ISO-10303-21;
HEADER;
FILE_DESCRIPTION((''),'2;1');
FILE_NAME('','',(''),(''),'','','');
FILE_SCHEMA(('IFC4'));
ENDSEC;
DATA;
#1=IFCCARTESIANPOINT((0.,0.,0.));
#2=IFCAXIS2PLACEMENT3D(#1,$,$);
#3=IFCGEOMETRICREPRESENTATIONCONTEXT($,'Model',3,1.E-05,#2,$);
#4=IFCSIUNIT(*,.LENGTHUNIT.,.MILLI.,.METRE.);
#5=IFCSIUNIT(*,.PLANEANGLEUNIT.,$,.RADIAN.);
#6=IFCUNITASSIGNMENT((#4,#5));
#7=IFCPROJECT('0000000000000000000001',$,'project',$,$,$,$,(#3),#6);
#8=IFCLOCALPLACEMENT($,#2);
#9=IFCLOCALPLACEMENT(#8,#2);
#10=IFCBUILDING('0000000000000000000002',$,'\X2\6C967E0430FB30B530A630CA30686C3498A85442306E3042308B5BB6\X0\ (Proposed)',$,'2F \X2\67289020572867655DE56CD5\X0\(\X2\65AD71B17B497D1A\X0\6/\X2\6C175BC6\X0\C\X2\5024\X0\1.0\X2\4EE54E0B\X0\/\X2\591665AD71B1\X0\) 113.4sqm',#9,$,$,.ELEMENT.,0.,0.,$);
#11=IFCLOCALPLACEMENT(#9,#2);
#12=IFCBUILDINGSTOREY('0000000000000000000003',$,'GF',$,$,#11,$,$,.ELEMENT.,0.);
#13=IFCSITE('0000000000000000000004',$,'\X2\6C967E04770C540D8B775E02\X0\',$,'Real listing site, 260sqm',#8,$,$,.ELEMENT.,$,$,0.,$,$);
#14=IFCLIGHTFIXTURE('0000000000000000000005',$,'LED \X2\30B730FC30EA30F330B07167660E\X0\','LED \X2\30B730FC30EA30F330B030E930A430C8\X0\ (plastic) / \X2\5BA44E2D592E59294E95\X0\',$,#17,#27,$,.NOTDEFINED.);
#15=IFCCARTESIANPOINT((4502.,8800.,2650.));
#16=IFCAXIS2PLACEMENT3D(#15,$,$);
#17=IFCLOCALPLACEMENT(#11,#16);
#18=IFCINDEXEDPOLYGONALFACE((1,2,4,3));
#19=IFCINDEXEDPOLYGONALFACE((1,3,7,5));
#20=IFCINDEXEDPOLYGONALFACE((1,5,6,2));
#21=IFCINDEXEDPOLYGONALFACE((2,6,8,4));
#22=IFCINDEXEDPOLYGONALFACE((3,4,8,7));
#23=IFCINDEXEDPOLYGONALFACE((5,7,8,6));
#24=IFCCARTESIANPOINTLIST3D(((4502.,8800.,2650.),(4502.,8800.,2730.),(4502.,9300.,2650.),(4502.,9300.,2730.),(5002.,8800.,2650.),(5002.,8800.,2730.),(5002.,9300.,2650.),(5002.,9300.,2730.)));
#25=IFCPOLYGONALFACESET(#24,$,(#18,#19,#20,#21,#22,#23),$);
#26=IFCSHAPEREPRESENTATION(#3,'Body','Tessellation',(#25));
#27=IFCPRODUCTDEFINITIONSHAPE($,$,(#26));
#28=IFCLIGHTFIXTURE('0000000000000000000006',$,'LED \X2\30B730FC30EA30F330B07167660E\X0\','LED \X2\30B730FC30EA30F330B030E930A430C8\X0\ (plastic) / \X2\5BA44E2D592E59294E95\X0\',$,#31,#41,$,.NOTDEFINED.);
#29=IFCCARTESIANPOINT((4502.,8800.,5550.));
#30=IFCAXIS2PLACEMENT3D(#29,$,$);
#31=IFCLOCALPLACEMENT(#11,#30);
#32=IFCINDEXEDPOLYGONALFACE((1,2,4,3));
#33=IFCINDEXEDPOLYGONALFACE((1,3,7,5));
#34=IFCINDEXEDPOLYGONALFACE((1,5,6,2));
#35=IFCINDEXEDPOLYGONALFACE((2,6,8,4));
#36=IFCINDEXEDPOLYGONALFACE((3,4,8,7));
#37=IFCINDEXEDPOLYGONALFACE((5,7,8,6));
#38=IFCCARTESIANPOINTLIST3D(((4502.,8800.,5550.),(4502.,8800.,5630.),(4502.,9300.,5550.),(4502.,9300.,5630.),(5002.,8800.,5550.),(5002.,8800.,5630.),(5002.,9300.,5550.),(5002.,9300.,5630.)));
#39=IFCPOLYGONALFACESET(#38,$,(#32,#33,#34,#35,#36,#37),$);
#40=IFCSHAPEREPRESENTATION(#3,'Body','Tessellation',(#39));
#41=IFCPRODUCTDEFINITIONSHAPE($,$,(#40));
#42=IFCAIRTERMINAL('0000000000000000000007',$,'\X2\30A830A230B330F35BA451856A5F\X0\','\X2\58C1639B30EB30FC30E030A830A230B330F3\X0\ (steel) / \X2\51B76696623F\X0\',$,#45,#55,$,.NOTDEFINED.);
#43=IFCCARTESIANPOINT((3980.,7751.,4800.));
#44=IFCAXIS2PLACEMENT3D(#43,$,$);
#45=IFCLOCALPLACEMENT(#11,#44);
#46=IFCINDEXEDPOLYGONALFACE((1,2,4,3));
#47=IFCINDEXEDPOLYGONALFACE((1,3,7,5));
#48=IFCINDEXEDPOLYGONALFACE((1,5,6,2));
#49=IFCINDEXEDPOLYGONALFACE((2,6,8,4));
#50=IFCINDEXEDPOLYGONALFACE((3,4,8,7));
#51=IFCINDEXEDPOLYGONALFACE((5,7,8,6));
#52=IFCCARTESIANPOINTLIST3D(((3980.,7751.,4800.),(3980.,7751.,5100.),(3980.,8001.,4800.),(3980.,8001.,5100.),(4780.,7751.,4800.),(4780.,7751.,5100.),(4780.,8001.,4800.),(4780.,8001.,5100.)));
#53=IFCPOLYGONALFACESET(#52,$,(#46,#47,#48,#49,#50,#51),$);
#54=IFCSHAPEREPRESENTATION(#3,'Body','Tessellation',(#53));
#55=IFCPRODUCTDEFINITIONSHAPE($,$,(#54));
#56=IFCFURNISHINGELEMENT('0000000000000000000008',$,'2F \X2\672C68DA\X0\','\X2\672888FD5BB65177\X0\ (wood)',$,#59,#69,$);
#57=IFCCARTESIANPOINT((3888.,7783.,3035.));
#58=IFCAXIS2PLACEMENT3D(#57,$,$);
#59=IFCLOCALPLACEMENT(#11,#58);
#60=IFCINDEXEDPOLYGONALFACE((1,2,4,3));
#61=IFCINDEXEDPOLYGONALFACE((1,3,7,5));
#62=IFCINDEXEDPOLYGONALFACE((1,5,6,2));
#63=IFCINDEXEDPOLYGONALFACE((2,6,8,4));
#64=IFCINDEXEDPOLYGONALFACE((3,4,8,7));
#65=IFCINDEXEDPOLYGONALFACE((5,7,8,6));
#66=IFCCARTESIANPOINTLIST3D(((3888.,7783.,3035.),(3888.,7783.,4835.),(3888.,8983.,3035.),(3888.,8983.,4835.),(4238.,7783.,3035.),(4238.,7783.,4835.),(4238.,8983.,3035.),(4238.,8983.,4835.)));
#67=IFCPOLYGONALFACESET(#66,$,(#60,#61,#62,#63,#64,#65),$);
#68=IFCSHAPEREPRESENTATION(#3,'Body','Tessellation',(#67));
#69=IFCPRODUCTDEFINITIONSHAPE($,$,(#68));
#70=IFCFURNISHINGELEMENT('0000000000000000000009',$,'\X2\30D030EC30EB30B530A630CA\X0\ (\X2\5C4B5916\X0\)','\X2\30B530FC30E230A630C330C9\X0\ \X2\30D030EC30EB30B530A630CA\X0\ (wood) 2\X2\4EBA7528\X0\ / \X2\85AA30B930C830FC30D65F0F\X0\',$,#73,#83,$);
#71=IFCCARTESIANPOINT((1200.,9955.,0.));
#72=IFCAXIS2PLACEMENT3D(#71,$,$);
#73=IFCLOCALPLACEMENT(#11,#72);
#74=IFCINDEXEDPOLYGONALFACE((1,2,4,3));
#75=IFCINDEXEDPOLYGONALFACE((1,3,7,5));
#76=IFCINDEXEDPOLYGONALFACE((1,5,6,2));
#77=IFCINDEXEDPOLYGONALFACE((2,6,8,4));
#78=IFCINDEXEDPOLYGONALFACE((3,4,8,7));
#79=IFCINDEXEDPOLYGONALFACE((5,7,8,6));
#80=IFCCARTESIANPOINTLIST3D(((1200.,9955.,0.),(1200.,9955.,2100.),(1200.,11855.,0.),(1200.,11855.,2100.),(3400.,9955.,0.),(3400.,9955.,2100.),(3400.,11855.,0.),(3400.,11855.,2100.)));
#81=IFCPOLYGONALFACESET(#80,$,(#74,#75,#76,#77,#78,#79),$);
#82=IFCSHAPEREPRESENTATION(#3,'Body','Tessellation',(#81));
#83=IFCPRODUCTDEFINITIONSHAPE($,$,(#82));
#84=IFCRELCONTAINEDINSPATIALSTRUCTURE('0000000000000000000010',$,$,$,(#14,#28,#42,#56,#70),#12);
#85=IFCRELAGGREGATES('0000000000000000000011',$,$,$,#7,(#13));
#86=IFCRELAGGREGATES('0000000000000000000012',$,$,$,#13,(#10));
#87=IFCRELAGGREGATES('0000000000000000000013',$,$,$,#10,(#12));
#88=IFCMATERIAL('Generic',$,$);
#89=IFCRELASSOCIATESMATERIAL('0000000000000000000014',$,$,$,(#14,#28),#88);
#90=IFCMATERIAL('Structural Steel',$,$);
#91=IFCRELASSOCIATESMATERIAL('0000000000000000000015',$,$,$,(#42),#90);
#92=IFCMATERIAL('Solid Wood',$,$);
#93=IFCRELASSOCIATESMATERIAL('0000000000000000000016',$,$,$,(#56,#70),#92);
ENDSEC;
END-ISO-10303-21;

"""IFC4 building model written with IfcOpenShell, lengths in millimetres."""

from ifc_helpers import new_model, si_unit, frame, frame_2d, origin, place, context, project, spatial, rectangle, extrude, material, element, save


model = new_model("IFC4")

# Units and contexts
model_context = context("Model", 3, precision=1e-05, world=origin())
ifc_project = project(units=[si_unit("LENGTHUNIT", "METRE", prefix="MILLI"), si_unit("PLANEANGLEUNIT", "RADIAN")], contexts=[model_context])

# Site, building, storey
site_placement = place(None, origin())
site = spatial("IfcSite", under=ifc_project, at=site_placement, Name="沖縄県名護市", ObjectType="Real listing site, 260sqm", CompositionType="ELEMENT", RefElevation=0.0)
building_placement = place(site_placement, origin())
building = spatial("IfcBuilding", under=site, at=building_placement, Name="沖縄・サウナと水風呂のある家 (Proposed)", ObjectType="2F 木造在来工法(断熱等級6/気密C値1.0以下/外断熱) 113.4sqm", CompositionType="ELEMENT", ElevationOfRefHeight=0.0, ElevationOfTerrain=0.0)
storey_placement = place(building_placement, origin())
storey = spatial("IfcBuildingStorey", under=building, at=storey_placement, Name="GF", CompositionType="ELEMENT", Elevation=0.0)

# Shared definitions
ifc_material_1 = material(Name="Solid Wood")

# Shared definitions
ifc_material_2 = material(Name="Structural Steel")

# Shared definitions
ifc_material_3 = material(Name="Generic")

# Light fixtures
light_fixture_1_placement = place(storey_placement, frame((4502.0, 8800.0, 2650.0)))
element("IfcLightFixture", 1, at=light_fixture_1_placement, inside=storey, material=ifc_material_3, Name="LED シーリング照明", Description="LED シーリングライト (plastic) / 室中央天井", PredefinedType="NOTDEFINED", context=model_context, shape_type="SweptSolid", body=[
    extrude(rectangle(XDim=500.0, YDim=500.0, at=frame_2d((250.0, 250.0))), frame((4502.0, 8800.0, 2650.0)), (0.0, 0.0, 1.0), 80.0),
])
light_fixture_2_placement = place(storey_placement, frame((4502.0, 8800.0, 5550.0)))
element("IfcLightFixture", 2, at=light_fixture_2_placement, inside=storey, material=ifc_material_3, Name="LED シーリング照明", Description="LED シーリングライト (plastic) / 室中央天井", PredefinedType="NOTDEFINED", context=model_context, shape_type="SweptSolid", body=[
    extrude(rectangle(XDim=500.0, YDim=500.0, at=frame_2d((250.0, 250.0))), frame((4502.0, 8800.0, 5550.0)), (0.0, 0.0, 1.0), 80.0),
])

# Air terminal
air_terminal_placement = place(storey_placement, frame((3980.0, 7751.0, 4800.0)))
element("IfcAirTerminal", 3, at=air_terminal_placement, inside=storey, material=ifc_material_2, Name="エアコン室内機", Description="壁掛ルームエアコン (steel) / 冷暖房", PredefinedType="NOTDEFINED", context=model_context, shape_type="SweptSolid", body=[
    extrude(rectangle(XDim=800.0, YDim=250.0, at=frame_2d((400.0, 125.0))), frame((3980.0, 7751.0, 4800.0)), (0.0, 0.0, 1.0), 300.0),
])

# Furnishing elements
furnishing_1_placement = place(storey_placement, frame((3888.0, 7783.0, 3035.0)))
element("IfcFurnishingElement", 4, at=furnishing_1_placement, inside=storey, material=ifc_material_1, Name="2F 本棚", Description="木製家具 (wood)", context=model_context, shape_type="SweptSolid", body=[
    extrude(rectangle(XDim=350.0, YDim=1200.0, at=frame_2d((175.0, 600.0))), frame((3888.0, 7783.0, 3035.0)), (0.0, 0.0, 1.0), 1800.0),
])
furnishing_2_placement = place(storey_placement, frame((1200.0, 9955.0, 0.0)))
element("IfcFurnishingElement", 5, at=furnishing_2_placement, inside=storey, material=ifc_material_1, Name="バレルサウナ (屋外)", Description="サーモウッド バレルサウナ (wood) 2人用 / 薪ストーブ式", context=model_context, shape_type="SweptSolid", body=[
    extrude(rectangle(XDim=2200.0, YDim=1900.0, at=frame_2d((1100.0, 950.0))), frame((1200.0, 9955.0, 0.0)), (0.0, 0.0, 1.0), 2100.0),
])

save(model, "model.ifc")
